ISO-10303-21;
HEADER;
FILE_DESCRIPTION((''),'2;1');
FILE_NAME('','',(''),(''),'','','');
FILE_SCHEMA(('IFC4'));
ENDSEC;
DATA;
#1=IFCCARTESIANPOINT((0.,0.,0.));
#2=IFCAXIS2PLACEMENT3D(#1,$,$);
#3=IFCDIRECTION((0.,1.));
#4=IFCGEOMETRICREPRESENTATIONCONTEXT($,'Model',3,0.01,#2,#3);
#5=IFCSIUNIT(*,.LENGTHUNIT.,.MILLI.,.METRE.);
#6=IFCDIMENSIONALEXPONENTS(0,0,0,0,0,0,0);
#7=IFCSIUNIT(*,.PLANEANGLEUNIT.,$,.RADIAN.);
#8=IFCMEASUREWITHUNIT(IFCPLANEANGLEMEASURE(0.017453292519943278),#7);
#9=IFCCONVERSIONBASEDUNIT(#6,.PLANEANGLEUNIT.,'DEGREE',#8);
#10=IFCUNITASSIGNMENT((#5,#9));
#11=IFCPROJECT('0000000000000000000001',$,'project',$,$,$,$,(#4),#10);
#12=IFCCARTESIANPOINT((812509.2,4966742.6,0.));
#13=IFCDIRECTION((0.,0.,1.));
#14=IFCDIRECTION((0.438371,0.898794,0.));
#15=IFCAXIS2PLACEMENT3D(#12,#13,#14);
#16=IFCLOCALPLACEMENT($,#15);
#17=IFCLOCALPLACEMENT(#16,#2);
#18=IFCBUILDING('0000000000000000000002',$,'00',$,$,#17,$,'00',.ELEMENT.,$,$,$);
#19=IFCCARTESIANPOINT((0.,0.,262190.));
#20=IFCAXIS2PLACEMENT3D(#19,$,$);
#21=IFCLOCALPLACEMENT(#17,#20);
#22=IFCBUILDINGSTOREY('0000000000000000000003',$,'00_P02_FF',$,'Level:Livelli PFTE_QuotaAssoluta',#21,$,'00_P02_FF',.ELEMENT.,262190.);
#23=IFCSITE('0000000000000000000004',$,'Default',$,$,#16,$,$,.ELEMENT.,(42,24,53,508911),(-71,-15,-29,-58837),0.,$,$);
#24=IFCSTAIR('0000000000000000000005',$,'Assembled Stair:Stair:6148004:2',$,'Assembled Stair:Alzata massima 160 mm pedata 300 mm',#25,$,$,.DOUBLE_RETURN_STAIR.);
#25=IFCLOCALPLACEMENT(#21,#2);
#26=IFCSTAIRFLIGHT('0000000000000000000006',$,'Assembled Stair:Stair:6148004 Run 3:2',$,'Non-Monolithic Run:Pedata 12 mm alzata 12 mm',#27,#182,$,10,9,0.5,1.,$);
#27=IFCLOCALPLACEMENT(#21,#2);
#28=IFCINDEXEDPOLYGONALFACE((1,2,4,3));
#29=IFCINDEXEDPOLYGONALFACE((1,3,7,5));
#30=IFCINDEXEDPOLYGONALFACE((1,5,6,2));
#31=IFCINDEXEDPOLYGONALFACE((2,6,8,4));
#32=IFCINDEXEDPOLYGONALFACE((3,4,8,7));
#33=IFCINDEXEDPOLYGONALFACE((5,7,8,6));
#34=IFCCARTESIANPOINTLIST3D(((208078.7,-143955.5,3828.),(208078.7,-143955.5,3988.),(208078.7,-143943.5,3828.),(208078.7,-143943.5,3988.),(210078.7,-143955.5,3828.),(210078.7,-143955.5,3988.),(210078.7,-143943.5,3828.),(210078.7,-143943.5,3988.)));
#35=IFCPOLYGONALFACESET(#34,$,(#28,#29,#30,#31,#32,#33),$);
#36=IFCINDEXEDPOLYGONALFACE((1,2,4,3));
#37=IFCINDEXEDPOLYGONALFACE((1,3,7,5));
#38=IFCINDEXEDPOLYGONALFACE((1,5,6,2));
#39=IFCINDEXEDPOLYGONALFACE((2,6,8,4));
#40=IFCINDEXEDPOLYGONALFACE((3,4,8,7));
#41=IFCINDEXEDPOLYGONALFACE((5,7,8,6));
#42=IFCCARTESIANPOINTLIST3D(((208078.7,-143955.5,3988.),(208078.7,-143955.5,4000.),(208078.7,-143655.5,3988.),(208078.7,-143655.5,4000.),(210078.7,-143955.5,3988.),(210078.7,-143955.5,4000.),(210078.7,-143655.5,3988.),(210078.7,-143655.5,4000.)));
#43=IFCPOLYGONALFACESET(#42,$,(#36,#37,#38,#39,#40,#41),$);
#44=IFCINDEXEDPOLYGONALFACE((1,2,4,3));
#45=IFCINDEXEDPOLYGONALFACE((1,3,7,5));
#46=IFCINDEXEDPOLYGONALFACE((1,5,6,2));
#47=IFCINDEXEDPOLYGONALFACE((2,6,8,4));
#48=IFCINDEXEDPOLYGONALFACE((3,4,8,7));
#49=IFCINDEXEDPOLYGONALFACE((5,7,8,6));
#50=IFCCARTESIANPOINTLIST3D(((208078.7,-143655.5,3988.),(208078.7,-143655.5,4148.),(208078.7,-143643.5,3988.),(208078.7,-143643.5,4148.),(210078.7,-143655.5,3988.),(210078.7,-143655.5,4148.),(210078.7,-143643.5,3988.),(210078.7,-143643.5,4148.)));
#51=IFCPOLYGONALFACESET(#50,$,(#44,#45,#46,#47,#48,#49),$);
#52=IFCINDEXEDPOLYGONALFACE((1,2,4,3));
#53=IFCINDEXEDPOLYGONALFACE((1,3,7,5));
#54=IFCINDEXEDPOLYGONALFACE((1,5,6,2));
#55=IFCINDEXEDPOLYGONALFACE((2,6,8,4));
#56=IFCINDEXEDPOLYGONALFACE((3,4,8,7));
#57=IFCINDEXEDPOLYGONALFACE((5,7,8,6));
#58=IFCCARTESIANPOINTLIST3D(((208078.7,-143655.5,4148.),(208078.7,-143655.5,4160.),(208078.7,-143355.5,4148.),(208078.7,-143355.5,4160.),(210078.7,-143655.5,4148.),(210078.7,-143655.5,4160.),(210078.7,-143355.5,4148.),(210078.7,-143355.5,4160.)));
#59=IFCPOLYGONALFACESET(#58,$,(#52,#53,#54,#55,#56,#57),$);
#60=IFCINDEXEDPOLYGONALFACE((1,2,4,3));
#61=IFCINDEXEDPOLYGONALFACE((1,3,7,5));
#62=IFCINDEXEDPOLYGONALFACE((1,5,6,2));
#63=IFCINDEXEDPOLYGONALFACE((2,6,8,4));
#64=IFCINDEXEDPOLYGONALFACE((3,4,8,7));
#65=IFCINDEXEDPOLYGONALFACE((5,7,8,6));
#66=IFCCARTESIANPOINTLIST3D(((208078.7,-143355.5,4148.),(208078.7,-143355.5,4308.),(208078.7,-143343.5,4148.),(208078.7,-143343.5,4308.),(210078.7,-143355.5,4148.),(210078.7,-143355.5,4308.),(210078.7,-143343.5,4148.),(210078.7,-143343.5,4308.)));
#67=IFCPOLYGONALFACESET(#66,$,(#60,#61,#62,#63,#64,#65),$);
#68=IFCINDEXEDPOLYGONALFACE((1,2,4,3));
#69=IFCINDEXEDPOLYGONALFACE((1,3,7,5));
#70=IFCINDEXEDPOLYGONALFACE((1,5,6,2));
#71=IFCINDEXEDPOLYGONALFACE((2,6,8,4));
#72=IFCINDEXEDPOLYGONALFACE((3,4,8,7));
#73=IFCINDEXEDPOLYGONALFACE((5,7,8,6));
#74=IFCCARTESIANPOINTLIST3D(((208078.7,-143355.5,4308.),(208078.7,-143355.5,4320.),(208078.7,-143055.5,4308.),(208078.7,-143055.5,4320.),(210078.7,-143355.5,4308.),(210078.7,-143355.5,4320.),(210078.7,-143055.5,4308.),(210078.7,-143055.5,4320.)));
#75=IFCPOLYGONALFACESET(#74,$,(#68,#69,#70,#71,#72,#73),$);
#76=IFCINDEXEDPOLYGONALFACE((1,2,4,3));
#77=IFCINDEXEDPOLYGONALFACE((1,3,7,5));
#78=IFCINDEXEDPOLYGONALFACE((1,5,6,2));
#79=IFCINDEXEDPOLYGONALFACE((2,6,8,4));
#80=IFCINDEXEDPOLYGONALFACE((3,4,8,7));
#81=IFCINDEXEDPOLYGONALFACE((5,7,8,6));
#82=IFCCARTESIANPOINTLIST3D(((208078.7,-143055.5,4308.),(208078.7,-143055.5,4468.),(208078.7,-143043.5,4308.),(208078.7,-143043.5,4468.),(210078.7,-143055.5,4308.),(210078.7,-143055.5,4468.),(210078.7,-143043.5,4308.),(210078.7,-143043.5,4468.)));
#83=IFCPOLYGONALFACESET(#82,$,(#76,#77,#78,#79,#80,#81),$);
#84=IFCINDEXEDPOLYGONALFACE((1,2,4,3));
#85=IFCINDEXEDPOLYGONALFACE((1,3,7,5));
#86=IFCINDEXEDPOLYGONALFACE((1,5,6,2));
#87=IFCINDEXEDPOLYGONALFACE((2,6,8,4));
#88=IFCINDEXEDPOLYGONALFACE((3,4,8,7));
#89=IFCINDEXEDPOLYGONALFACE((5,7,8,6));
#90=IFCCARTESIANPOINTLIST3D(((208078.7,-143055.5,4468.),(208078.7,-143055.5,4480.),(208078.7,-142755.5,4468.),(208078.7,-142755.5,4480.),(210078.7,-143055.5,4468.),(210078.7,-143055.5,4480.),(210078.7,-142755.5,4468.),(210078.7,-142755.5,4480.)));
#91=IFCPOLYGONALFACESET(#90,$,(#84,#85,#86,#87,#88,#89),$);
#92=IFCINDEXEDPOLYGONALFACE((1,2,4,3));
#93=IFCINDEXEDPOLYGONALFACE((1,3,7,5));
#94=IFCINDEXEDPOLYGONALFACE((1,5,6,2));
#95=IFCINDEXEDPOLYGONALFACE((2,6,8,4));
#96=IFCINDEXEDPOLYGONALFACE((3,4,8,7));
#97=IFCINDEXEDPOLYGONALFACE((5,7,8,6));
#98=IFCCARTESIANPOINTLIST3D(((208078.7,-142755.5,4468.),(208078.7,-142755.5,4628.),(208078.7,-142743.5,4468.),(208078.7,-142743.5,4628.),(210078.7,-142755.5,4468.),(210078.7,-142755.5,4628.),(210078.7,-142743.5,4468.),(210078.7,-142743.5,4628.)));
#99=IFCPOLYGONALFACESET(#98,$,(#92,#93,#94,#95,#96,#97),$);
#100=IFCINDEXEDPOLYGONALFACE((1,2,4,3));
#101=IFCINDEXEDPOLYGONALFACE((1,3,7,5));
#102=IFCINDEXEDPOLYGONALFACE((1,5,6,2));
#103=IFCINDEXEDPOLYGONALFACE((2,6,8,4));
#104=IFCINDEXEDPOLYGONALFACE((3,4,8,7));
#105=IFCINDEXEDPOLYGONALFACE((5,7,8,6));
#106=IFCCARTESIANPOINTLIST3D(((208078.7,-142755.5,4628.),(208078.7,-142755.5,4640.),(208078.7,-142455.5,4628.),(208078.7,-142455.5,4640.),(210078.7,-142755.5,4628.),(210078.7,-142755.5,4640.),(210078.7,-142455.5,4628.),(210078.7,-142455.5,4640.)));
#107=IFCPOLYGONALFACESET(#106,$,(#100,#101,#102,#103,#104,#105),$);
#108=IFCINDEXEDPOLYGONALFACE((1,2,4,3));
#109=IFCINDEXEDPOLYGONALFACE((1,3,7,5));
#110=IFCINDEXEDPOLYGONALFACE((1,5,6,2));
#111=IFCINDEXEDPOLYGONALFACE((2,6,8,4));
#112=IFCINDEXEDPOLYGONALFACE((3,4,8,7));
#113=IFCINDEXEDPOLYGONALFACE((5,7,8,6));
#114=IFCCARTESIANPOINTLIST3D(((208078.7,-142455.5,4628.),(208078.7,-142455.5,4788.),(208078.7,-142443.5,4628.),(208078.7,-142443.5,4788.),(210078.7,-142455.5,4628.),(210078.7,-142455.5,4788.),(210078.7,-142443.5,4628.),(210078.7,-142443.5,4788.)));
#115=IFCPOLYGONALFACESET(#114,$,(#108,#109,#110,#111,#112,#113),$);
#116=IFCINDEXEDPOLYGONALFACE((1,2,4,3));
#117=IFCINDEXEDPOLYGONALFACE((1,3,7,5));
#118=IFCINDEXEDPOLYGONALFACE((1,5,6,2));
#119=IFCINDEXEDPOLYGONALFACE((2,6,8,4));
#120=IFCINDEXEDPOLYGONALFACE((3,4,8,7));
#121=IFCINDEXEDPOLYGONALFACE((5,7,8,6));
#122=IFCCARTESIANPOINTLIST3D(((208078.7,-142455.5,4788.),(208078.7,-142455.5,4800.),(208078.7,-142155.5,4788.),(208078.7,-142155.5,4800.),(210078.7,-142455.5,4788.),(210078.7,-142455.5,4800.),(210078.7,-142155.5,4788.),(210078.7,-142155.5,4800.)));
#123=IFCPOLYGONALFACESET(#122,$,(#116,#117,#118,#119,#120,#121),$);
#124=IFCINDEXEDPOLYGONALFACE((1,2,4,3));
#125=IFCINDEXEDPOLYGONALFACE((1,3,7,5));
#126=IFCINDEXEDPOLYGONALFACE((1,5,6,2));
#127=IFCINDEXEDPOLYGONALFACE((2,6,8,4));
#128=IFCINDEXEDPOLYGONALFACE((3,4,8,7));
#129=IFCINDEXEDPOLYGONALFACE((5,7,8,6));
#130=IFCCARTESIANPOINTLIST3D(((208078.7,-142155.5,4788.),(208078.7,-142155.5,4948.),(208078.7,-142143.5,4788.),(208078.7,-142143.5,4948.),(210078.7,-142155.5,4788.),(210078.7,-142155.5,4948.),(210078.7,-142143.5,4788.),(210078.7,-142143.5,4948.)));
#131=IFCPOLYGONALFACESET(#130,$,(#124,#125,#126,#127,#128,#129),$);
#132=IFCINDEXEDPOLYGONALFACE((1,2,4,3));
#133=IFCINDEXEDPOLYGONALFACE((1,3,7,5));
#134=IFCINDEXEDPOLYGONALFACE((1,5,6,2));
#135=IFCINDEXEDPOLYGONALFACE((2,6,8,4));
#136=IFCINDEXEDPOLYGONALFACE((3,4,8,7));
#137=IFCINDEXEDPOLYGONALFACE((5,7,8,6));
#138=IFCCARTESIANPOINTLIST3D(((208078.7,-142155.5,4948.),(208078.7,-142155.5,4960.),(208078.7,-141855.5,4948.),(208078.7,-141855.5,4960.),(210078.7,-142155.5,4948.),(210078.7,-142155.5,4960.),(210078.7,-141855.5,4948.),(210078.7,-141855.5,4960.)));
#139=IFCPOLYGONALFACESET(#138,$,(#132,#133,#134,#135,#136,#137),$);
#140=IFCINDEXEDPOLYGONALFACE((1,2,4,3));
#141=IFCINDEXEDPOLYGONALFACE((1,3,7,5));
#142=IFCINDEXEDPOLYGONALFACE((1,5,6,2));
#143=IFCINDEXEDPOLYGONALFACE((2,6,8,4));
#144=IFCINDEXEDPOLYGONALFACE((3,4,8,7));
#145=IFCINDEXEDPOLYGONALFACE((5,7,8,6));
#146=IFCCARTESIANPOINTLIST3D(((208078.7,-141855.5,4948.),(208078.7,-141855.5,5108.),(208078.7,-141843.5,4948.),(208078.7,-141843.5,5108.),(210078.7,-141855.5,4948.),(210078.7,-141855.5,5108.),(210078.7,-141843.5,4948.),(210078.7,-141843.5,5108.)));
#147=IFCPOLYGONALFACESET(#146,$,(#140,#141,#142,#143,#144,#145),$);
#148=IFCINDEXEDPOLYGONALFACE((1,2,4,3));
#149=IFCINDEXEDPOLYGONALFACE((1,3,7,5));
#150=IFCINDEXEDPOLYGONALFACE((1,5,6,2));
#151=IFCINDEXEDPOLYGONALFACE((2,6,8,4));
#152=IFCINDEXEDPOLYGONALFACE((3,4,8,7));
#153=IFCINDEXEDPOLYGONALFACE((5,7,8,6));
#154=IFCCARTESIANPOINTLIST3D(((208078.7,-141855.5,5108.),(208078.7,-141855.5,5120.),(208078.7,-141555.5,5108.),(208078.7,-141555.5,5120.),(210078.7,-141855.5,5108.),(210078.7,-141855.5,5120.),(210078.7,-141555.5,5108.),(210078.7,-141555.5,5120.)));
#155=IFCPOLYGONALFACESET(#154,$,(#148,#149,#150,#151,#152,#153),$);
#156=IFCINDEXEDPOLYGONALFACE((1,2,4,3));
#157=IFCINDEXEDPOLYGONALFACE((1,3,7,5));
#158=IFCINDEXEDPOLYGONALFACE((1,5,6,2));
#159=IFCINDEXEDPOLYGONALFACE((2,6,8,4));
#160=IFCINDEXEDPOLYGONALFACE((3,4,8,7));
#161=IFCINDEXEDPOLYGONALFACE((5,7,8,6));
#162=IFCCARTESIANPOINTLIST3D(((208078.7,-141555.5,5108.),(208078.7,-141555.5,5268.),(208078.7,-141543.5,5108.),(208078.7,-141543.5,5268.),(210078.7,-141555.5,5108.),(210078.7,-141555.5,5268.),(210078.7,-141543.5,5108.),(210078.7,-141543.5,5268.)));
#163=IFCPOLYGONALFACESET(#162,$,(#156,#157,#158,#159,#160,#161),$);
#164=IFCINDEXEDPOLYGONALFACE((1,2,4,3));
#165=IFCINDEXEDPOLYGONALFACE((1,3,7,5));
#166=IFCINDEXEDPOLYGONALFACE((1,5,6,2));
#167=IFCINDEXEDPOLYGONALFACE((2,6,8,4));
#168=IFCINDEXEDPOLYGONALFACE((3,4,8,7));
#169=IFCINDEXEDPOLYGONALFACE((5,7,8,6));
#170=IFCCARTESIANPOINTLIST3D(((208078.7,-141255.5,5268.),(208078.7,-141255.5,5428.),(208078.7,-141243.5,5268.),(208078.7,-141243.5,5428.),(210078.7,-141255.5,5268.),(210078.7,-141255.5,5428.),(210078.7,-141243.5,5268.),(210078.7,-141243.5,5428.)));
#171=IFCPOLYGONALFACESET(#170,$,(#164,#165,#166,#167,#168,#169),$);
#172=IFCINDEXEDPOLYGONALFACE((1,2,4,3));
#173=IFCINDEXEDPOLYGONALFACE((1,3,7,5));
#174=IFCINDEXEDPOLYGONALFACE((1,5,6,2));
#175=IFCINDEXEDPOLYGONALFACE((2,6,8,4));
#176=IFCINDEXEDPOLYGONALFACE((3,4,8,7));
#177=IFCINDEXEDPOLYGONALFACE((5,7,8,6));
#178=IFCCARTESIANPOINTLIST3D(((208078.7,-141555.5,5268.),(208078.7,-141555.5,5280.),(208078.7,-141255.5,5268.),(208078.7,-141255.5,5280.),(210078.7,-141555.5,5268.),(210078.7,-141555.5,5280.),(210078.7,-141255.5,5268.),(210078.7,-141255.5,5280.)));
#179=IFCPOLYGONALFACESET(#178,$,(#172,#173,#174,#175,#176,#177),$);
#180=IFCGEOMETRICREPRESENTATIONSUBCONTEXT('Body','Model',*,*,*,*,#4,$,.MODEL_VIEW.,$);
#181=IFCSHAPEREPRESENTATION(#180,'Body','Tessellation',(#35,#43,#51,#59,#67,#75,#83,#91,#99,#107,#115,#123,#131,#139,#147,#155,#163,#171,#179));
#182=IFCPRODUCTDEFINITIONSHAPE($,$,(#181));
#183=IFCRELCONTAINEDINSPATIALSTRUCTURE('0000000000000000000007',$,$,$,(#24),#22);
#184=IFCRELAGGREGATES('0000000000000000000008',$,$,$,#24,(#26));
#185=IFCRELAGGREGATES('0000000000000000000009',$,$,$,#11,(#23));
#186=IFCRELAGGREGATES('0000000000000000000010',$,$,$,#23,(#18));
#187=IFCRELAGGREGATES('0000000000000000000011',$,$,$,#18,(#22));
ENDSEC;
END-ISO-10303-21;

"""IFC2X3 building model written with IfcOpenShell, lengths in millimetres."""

from ifc_helpers import new_model, entity, si_unit, converted_unit, direction, frame, origin, origin_2d_with_axis, place, context, subcontext, project, spatial, rectangle, extrude, element, aggregate, save


model = new_model("IFC2X3")

# Units and contexts
model_context = context("Model", 3, precision=0.01, world=origin(), true_north=direction((0.0, 1.0)))
body_context = subcontext(model_context, "Body", "Model", "MODEL_VIEW")
ifc_project = project(units=[si_unit("LENGTHUNIT", "METRE", prefix="MILLI"), converted_unit("PLANEANGLEUNIT", "DEGREE", entity("IfcPlaneAngleMeasure", 0.017453292519943278), si_unit("PLANEANGLEUNIT", "RADIAN"), dimensions=[0, 0, 0, 0, 0, 0, 0])], contexts=[model_context])

# Site, building, storey
site_placement = place(None, frame((812509.2, 4966742.6, 0.0), z_axis=(0.0, 0.0, 1.0), x_axis=(0.438371, 0.898794, 0.0)))
site = spatial("IfcSite", under=ifc_project, at=site_placement, Name="Default", CompositionType="ELEMENT", RefLatitude=(42, 24, 53, 508911), RefLongitude=(-71, -15, -29, -58837), RefElevation=0.0)
building_placement = place(site_placement, origin())
building = spatial("IfcBuilding", under=site, at=building_placement, Name="00", LongName="00", CompositionType="ELEMENT")
storey_placement = place(building_placement, frame((0.0, 0.0, 262190.0)))
storey = spatial("IfcBuildingStorey", under=building, at=storey_placement, Name="00_P02_FF", ObjectType="Level:Livelli PFTE_QuotaAssoluta", LongName="00_P02_FF", CompositionType="ELEMENT", Elevation=262190.0)

# Stair
stair_1_placement = place(storey_placement, origin())
stair_1 = element("IfcStair", 1, at=stair_1_placement, inside=storey, Name="Assembled Stair:Stair:6148004:2", ObjectType="Assembled Stair:Alzata massima 160 mm pedata 300 mm", ShapeType="DOUBLE_RETURN_STAIR")

# Stair flight
stair_flight_1_placement = place(stair_1_placement, origin())
stair_flight_1 = element("IfcStairFlight", 2, at=stair_flight_1_placement, Name="Assembled Stair:Stair:6148004 Run 3:2", ObjectType="Non-Monolithic Run:Pedata 12 mm alzata 12 mm", NumberOfRiser=10, NumberOfTreads=9, RiserHeight=0.5, TreadLength=1.0, context=body_context, shape_type="SweptSolid", body=[
    extrude(rectangle(XDim=2000.0, YDim=12.0, at=origin_2d_with_axis()), frame((209078.7, -143949.5, 3828.0), z_axis=(0.0, 0.0, 1.0), x_axis=(-1.0, 0.0, 0.0)), (0.0, 0.0, 1.0), 160.0),
    extrude(rectangle(XDim=300.0, YDim=2000.0, at=origin_2d_with_axis()), frame((209078.7, -143805.5, 3988.0), z_axis=(0.0, 0.0, 1.0), x_axis=(0.0, -1.0, 0.0)), (0.0, 0.0, 1.0), 12.0),
    extrude(rectangle(XDim=2000.0, YDim=12.0, at=origin_2d_with_axis()), frame((209078.7, -143649.5, 3988.0), z_axis=(0.0, 0.0, 1.0), x_axis=(-1.0, 0.0, 0.0)), (0.0, 0.0, 1.0), 160.0),
    extrude(rectangle(XDim=300.0, YDim=2000.0, at=origin_2d_with_axis()), frame((209078.7, -143505.5, 4148.0), z_axis=(0.0, 0.0, 1.0), x_axis=(0.0, -1.0, 0.0)), (0.0, 0.0, 1.0), 12.0),
    extrude(rectangle(XDim=2000.0, YDim=12.0, at=origin_2d_with_axis()), frame((209078.7, -143349.5, 4148.0), z_axis=(0.0, 0.0, 1.0), x_axis=(-1.0, 0.0, 0.0)), (0.0, 0.0, 1.0), 160.0),
    extrude(rectangle(XDim=300.0, YDim=2000.0, at=origin_2d_with_axis()), frame((209078.7, -143205.5, 4308.0), z_axis=(0.0, 0.0, 1.0), x_axis=(0.0, -1.0, 0.0)), (0.0, 0.0, 1.0), 12.0),
    extrude(rectangle(XDim=2000.0, YDim=12.0, at=origin_2d_with_axis()), frame((209078.7, -143049.5, 4308.0), z_axis=(0.0, 0.0, 1.0), x_axis=(-1.0, 0.0, 0.0)), (0.0, 0.0, 1.0), 160.0),
    extrude(rectangle(XDim=300.0, YDim=2000.0, at=origin_2d_with_axis()), frame((209078.7, -142905.5, 4468.0), z_axis=(0.0, 0.0, 1.0), x_axis=(0.0, -1.0, 0.0)), (0.0, 0.0, 1.0), 12.0),
    extrude(rectangle(XDim=2000.0, YDim=12.0, at=origin_2d_with_axis()), frame((209078.7, -142749.5, 4468.0), z_axis=(0.0, 0.0, 1.0), x_axis=(-1.0, 0.0, 0.0)), (0.0, 0.0, 1.0), 160.0),
    extrude(rectangle(XDim=300.0, YDim=2000.0, at=origin_2d_with_axis()), frame((209078.7, -142605.5, 4628.0), z_axis=(0.0, 0.0, 1.0), x_axis=(0.0, -1.0, 0.0)), (0.0, 0.0, 1.0), 12.0),
    extrude(rectangle(XDim=2000.0, YDim=12.0, at=origin_2d_with_axis()), frame((209078.7, -142449.5, 4628.0), z_axis=(0.0, 0.0, 1.0), x_axis=(-1.0, 0.0, 0.0)), (0.0, 0.0, 1.0), 160.0),
    extrude(rectangle(XDim=300.0, YDim=2000.0, at=origin_2d_with_axis()), frame((209078.7, -142305.5, 4788.0), z_axis=(0.0, 0.0, 1.0), x_axis=(0.0, -1.0, 0.0)), (0.0, 0.0, 1.0), 12.0),
    extrude(rectangle(XDim=2000.0, YDim=12.0, at=origin_2d_with_axis()), frame((209078.7, -142149.5, 4788.0), z_axis=(0.0, 0.0, 1.0), x_axis=(-1.0, 0.0, 0.0)), (0.0, 0.0, 1.0), 160.0),
    extrude(rectangle(XDim=300.0, YDim=2000.0, at=origin_2d_with_axis()), frame((209078.7, -142005.5, 4948.0), z_axis=(0.0, 0.0, 1.0), x_axis=(0.0, -1.0, 0.0)), (0.0, 0.0, 1.0), 12.0),
    extrude(rectangle(XDim=2000.0, YDim=12.0, at=origin_2d_with_axis()), frame((209078.7, -141849.5, 4948.0), z_axis=(0.0, 0.0, 1.0), x_axis=(-1.0, 0.0, 0.0)), (0.0, 0.0, 1.0), 160.0),
    extrude(rectangle(XDim=300.0, YDim=2000.0, at=origin_2d_with_axis()), frame((209078.7, -141705.5, 5108.0), z_axis=(0.0, 0.0, 1.0), x_axis=(0.0, -1.0, 0.0)), (0.0, 0.0, 1.0), 12.0),
    extrude(rectangle(XDim=2000.0, YDim=12.0, at=origin_2d_with_axis()), frame((209078.7, -141549.5, 5108.0), z_axis=(0.0, 0.0, 1.0), x_axis=(-1.0, 0.0, 0.0)), (0.0, 0.0, 1.0), 160.0),
    extrude(rectangle(XDim=2000.0, YDim=12.0, at=origin_2d_with_axis()), frame((209078.7, -141249.5, 5268.0), z_axis=(0.0, 0.0, 1.0), x_axis=(-1.0, 0.0, 0.0)), (0.0, 0.0, 1.0), 160.0),
    extrude(rectangle(XDim=300.0, YDim=2000.0, at=origin_2d_with_axis()), frame((209078.7, -141405.5, 5268.0), z_axis=(0.0, 0.0, 1.0), x_axis=(0.0, -1.0, 0.0)), (0.0, 0.0, 1.0), 12.0),
])
aggregate(stair_1, [stair_flight_1])

save(model, "model.ifc")
